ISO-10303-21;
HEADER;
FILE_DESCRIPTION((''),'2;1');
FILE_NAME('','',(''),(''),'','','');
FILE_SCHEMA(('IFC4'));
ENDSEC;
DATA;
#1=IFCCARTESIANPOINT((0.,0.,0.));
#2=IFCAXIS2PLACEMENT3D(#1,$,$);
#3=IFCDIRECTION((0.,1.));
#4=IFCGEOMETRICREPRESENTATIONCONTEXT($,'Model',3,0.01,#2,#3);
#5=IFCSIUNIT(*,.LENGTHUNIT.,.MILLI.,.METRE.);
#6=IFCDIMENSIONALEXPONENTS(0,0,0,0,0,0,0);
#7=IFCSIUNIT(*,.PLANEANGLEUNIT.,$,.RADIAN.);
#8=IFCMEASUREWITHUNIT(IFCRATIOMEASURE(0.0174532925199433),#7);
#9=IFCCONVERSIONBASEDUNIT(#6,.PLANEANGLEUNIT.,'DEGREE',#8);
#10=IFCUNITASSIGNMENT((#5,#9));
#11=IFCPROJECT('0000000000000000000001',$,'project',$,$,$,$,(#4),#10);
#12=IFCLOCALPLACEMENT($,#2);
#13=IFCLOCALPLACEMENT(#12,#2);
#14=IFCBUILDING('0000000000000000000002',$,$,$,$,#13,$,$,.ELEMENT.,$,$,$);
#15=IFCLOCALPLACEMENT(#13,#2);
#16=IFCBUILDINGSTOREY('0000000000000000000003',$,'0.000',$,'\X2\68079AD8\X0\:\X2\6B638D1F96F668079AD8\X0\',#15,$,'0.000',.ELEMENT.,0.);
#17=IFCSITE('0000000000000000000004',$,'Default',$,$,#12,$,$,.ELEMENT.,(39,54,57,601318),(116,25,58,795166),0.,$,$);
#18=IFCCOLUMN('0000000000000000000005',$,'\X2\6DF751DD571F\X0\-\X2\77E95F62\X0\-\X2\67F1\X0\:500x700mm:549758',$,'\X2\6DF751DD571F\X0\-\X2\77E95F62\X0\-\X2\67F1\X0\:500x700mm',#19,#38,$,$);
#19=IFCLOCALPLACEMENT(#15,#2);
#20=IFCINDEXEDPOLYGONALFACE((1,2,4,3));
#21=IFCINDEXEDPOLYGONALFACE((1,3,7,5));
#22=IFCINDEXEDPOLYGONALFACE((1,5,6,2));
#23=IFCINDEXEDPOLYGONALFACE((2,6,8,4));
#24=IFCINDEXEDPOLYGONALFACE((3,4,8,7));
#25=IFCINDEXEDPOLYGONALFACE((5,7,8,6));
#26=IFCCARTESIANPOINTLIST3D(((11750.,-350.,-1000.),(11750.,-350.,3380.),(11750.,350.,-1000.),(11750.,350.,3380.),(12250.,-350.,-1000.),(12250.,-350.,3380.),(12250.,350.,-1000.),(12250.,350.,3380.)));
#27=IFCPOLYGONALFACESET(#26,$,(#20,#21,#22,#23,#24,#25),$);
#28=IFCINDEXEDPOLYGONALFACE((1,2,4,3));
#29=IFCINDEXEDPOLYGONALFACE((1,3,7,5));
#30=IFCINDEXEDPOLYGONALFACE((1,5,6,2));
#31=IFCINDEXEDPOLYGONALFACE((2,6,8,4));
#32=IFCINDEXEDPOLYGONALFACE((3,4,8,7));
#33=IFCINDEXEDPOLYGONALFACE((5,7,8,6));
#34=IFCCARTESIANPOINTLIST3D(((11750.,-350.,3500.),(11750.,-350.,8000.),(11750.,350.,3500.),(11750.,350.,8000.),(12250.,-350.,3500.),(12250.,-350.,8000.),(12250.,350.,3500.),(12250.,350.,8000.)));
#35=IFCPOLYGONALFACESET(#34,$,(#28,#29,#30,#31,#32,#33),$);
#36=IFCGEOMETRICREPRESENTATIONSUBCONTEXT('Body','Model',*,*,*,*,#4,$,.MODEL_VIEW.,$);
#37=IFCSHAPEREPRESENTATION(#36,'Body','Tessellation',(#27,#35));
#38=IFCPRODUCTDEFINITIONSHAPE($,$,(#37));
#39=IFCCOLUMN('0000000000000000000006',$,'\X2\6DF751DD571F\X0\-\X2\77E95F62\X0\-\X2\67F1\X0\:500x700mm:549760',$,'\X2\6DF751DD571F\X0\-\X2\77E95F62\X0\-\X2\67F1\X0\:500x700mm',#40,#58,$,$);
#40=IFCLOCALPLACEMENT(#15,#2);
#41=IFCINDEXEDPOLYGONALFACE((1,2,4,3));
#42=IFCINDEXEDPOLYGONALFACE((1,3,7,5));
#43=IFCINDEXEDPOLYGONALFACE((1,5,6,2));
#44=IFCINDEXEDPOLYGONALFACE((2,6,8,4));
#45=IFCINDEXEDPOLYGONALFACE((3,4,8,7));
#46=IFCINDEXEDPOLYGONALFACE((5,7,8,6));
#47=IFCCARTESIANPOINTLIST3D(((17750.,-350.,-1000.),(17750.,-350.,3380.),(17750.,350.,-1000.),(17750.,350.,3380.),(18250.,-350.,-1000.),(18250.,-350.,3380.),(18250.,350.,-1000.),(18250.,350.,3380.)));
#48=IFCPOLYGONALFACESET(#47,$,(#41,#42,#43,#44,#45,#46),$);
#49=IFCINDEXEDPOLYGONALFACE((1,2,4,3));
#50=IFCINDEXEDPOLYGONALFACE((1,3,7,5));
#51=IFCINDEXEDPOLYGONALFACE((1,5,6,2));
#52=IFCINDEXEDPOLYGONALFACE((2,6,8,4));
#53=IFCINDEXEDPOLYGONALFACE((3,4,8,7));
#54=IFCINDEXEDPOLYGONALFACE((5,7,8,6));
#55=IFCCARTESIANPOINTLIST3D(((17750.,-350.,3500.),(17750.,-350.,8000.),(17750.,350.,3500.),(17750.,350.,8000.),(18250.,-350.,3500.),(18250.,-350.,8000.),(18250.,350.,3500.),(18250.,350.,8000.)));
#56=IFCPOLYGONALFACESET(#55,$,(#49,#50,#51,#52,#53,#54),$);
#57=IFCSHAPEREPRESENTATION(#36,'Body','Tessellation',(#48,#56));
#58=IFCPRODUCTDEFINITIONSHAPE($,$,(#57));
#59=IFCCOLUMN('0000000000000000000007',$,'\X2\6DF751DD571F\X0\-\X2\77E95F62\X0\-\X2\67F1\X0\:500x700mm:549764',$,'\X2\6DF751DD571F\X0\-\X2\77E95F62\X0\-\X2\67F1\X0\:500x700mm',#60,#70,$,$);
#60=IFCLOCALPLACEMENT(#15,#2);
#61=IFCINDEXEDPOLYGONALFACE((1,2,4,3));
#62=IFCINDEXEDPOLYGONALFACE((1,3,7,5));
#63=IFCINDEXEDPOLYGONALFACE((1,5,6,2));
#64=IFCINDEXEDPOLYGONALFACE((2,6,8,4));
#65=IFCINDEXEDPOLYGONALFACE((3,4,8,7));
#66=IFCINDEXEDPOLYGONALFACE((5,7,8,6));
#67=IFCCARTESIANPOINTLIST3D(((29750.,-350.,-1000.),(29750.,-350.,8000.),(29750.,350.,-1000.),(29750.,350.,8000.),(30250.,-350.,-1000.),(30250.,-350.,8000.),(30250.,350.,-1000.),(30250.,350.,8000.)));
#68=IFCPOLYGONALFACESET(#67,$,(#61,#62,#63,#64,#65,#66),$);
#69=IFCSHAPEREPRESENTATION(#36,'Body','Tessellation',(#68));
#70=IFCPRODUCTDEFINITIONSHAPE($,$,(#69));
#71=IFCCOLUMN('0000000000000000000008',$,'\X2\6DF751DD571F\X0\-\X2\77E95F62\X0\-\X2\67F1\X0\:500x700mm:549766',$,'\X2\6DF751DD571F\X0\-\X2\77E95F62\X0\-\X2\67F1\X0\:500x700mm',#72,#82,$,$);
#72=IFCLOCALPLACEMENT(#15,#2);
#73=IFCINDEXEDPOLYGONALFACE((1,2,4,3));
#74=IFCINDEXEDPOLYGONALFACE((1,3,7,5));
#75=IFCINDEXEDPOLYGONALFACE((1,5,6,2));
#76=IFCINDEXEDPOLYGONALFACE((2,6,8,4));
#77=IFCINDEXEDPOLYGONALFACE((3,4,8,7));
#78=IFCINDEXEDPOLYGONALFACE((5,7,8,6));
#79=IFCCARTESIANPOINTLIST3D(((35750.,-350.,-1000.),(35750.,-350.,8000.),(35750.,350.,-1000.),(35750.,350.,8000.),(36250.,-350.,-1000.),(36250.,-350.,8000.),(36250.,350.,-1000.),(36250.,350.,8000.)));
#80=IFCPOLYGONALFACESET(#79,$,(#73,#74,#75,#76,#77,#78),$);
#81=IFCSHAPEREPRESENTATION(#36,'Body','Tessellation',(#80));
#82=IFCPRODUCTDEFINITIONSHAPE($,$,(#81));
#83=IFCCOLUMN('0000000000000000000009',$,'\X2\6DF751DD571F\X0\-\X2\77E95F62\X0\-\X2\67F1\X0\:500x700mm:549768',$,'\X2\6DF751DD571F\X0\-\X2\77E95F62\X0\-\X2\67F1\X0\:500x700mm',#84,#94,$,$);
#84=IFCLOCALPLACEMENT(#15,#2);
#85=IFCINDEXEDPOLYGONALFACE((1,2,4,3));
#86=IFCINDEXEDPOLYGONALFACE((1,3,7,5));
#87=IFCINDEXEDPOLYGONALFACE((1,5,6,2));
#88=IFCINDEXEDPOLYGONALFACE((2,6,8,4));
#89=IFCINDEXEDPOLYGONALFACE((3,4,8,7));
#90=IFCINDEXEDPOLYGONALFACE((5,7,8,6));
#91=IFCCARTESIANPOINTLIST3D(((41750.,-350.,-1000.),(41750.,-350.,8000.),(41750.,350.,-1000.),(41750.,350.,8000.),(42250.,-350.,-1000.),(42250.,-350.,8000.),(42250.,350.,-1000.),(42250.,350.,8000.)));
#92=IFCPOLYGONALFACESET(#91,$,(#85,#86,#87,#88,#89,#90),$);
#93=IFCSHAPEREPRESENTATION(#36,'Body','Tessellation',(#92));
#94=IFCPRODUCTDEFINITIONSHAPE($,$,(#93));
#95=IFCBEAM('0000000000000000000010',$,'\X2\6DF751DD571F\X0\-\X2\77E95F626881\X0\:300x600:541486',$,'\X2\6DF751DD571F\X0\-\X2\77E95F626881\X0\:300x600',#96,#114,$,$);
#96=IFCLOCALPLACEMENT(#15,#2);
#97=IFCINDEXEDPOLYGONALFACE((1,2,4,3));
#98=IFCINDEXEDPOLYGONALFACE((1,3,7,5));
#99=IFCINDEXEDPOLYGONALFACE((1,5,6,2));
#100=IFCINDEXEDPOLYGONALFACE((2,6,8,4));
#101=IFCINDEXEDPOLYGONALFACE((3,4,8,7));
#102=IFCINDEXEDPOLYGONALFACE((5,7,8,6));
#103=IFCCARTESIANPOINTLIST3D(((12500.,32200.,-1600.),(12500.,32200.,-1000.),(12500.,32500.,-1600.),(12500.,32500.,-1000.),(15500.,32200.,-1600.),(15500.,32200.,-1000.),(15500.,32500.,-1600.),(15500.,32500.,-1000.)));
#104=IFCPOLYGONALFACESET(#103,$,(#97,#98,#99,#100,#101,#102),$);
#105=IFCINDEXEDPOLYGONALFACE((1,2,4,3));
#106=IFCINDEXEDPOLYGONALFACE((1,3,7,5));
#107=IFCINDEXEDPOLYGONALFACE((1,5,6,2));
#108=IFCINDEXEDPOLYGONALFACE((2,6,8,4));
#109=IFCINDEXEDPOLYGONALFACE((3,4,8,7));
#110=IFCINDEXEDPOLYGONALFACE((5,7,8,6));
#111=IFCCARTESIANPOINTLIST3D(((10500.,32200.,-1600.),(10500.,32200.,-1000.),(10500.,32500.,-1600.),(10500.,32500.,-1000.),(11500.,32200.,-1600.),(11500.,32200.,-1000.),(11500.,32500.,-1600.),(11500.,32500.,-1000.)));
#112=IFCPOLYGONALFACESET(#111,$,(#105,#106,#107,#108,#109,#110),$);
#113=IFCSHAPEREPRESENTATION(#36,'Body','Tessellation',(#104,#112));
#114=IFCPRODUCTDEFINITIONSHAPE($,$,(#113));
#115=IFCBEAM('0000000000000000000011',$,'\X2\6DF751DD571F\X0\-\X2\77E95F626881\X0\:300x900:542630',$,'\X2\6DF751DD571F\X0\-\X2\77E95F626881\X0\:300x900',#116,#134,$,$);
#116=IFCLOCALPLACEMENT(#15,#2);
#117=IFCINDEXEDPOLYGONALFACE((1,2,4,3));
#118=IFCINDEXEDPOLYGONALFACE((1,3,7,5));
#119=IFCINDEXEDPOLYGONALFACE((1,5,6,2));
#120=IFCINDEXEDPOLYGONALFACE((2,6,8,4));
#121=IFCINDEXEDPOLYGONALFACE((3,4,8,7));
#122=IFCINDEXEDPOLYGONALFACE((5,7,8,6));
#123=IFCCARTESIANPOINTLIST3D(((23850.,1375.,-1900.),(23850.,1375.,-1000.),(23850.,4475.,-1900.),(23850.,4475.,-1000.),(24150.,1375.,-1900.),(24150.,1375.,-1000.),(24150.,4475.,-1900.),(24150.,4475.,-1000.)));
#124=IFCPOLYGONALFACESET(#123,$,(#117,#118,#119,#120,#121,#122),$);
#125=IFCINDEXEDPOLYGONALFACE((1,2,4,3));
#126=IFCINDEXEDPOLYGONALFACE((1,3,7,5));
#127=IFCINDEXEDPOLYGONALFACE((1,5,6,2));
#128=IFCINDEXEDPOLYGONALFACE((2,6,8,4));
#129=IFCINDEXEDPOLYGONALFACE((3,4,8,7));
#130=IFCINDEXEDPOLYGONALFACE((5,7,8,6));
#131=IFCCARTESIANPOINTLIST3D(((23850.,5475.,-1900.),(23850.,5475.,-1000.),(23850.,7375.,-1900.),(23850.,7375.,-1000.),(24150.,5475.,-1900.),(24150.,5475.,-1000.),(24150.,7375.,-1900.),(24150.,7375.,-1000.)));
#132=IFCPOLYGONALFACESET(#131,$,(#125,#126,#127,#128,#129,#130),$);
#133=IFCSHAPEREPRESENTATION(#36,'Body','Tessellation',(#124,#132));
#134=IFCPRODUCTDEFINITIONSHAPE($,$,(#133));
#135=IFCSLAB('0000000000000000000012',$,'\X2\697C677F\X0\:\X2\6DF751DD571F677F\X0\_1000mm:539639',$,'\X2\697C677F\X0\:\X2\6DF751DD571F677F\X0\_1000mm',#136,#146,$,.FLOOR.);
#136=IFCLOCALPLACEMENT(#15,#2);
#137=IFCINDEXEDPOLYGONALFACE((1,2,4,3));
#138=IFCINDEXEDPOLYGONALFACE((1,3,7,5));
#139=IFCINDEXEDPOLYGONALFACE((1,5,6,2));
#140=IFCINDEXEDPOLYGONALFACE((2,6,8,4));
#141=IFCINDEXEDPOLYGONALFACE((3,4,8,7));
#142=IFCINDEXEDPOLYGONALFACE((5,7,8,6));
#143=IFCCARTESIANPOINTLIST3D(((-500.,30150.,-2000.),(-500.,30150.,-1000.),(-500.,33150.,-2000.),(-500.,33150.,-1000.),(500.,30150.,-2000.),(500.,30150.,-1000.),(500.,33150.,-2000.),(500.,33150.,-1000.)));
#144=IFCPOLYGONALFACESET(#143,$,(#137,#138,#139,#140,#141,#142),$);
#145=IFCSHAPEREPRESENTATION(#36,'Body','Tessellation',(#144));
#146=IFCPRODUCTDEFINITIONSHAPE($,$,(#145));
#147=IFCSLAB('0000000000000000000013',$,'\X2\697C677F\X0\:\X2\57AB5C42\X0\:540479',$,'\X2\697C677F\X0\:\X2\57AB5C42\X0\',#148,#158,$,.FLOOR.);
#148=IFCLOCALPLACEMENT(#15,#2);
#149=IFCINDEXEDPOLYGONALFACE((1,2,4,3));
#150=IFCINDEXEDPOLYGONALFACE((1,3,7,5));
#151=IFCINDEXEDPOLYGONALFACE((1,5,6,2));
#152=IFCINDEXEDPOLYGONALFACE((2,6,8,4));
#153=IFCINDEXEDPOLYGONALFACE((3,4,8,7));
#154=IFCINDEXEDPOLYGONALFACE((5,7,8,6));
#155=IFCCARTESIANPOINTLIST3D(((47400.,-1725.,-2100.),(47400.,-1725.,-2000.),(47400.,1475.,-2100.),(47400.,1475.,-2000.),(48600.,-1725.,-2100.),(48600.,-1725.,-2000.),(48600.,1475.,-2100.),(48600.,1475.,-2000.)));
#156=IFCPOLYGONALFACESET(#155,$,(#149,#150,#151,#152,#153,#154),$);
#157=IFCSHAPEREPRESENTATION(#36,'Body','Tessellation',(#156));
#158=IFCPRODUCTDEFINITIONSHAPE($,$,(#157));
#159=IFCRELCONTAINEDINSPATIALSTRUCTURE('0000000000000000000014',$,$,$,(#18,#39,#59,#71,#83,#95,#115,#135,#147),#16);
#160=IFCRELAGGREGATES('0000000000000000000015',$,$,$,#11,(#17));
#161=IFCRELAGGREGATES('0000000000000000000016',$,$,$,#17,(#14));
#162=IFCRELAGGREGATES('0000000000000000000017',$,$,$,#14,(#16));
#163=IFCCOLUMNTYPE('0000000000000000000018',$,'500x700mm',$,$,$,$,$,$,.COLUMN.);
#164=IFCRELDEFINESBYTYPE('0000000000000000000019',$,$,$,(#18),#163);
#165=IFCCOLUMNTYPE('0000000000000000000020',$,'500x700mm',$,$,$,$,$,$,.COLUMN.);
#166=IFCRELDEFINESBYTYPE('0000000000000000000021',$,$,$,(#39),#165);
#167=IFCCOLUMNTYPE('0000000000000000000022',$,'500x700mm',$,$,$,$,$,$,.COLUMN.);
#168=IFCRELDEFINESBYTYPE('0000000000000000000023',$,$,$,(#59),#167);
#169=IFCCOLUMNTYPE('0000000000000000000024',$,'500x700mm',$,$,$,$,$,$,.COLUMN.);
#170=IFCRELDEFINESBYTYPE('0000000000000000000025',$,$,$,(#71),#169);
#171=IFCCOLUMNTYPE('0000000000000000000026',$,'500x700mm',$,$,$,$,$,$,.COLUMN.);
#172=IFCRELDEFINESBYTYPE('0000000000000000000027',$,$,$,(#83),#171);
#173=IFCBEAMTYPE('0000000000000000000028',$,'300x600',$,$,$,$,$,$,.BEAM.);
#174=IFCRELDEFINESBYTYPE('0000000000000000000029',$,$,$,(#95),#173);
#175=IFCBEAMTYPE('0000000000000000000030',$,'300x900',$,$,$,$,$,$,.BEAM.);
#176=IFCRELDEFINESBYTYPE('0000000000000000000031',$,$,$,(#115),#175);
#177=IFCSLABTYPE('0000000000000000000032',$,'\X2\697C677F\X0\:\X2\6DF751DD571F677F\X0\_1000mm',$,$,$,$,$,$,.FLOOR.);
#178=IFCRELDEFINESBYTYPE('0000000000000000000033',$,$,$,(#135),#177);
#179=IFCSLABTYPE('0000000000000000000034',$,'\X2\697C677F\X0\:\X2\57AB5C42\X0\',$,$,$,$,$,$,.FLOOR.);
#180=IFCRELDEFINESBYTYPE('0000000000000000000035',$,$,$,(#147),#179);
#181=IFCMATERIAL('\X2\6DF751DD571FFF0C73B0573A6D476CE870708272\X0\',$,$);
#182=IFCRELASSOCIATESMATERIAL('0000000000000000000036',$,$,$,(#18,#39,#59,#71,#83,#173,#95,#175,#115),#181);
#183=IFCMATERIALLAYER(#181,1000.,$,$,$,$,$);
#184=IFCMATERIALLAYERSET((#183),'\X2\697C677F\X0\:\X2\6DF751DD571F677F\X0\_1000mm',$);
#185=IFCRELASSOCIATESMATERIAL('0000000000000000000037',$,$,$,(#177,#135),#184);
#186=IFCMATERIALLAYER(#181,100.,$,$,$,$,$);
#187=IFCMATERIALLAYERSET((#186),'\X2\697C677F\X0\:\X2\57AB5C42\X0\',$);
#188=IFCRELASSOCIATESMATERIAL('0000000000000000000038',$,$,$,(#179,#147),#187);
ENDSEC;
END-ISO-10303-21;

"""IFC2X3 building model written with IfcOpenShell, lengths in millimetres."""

from ifc_helpers import new_model, entity, si_unit, converted_unit, direction, frame, frame_2d, origin, origin_2d_with_axis, place, context, subcontext, project, spatial, rectangle, extrude, source, transform, mapped, material, layer, layer_set, layer_usage, type_object, type_shapes, element, save


model = new_model("IFC2X3")

# Units and contexts
model_context = context("Model", 3, precision=0.01, world=origin(), true_north=direction((0.0, 1.0)))
body_context = subcontext(model_context, "Body", "Model", "MODEL_VIEW")
ifc_project = project(units=[si_unit("LENGTHUNIT", "METRE", prefix="MILLI"), converted_unit("PLANEANGLEUNIT", "DEGREE", entity("IfcRatioMeasure", 0.0174532925199433), si_unit("PLANEANGLEUNIT", "RADIAN"), dimensions=[0, 0, 0, 0, 0, 0, 0])], contexts=[model_context])

# Site, building, storey
site_placement = place(None, origin())
site = spatial("IfcSite", under=ifc_project, at=site_placement, Name="Default", CompositionType="ELEMENT", RefLatitude=(39, 54, 57, 601318), RefLongitude=(116, 25, 58, 795166), RefElevation=0.0)
building_placement = place(site_placement, origin())
building = spatial("IfcBuilding", under=site, at=building_placement, CompositionType="ELEMENT")
storey_placement = place(building_placement, origin())
storey = spatial("IfcBuildingStorey", under=building, at=storey_placement, Name="0.000", ObjectType="标高:正负零标高", LongName="0.000", CompositionType="ELEMENT", Elevation=0.0)

# Columns
ifc_material_1 = material(Name="混凝土，现场浇注灰色")
column_type_1 = type_object("IfcColumnType", Name="500x700mm", PredefinedType="COLUMN")
shared_shape_1 = source(origin(), body_context, "Body", "SweptSolid", [
    extrude(rectangle(XDim=700.0, YDim=500.0, at=origin_2d_with_axis()), frame((12000.0, 0.0, -1000.0), z_axis=(0.0, 0.0, 1.0), x_axis=(0.0, -1.0, 0.0)), (0.0, 0.0, 1.0), 4380.0),
    extrude(rectangle(XDim=700.0, YDim=500.0, at=origin_2d_with_axis()), frame((12000.0, 0.0, 3500.0), z_axis=(0.0, 0.0, 1.0), x_axis=(0.0, -1.0, 0.0)), (0.0, 0.0, 1.0), 4500.0),
])
type_shapes(column_type_1, [shared_shape_1])
column_1_placement = place(storey_placement, origin())
element("IfcColumn", 1, at=column_1_placement, inside=storey, type_object=column_type_1, material=ifc_material_1, Name="混凝土-矩形-柱:500x700mm:549758", ObjectType="混凝土-矩形-柱:500x700mm", context=body_context, shape_type="MappedRepresentation", body=[
    mapped(shared_shape_1, transform((0.0, 0.0, 0.0), scale=1.0)),
])
column_type_2 = type_object("IfcColumnType", Name="500x700mm", PredefinedType="COLUMN")
shared_shape_2 = source(origin(), body_context, "Body", "SweptSolid", [
    extrude(rectangle(XDim=700.0, YDim=500.0, at=origin_2d_with_axis()), frame((18000.0, 0.0, -1000.0), z_axis=(0.0, 0.0, 1.0), x_axis=(0.0, -1.0, 0.0)), (0.0, 0.0, 1.0), 4380.0),
    extrude(rectangle(XDim=700.0, YDim=500.0, at=origin_2d_with_axis()), frame((18000.0, 0.0, 3500.0), z_axis=(0.0, 0.0, 1.0), x_axis=(0.0, -1.0, 0.0)), (0.0, 0.0, 1.0), 4500.0),
])
type_shapes(column_type_2, [shared_shape_2])
column_2_placement = place(storey_placement, origin())
element("IfcColumn", 2, at=column_2_placement, inside=storey, type_object=column_type_2, material=ifc_material_1, Name="混凝土-矩形-柱:500x700mm:549760", ObjectType="混凝土-矩形-柱:500x700mm", context=body_context, shape_type="MappedRepresentation", body=[
    mapped(shared_shape_2, transform((0.0, 0.0, 0.0), scale=1.0)),
])
column_type_3 = type_object("IfcColumnType", Name="500x700mm", PredefinedType="COLUMN")
shared_shape_3 = source(origin(), body_context, "Body", "SweptSolid", [
    extrude(rectangle(XDim=700.0, YDim=500.0, at=origin_2d_with_axis()), frame((30000.0, 0.0, -1000.0), z_axis=(0.0, 0.0, 1.0), x_axis=(0.0, -1.0, 0.0)), (0.0, 0.0, 1.0), 9000.0),
])
type_shapes(column_type_3, [shared_shape_3])
column_3_placement = place(storey_placement, origin())
element("IfcColumn", 3, at=column_3_placement, inside=storey, type_object=column_type_3, material=ifc_material_1, Name="混凝土-矩形-柱:500x700mm:549764", ObjectType="混凝土-矩形-柱:500x700mm", context=body_context, shape_type="MappedRepresentation", body=[
    mapped(shared_shape_3, transform((0.0, 0.0, 0.0), scale=1.0)),
])
column_type_4 = type_object("IfcColumnType", Name="500x700mm", PredefinedType="COLUMN")
shared_shape_4 = source(origin(), body_context, "Body", "SweptSolid", [
    extrude(rectangle(XDim=700.0, YDim=500.0, at=origin_2d_with_axis()), frame((36000.0, 0.0, -1000.0), z_axis=(0.0, 0.0, 1.0), x_axis=(0.0, -1.0, 0.0)), (0.0, 0.0, 1.0), 9000.0),
])
type_shapes(column_type_4, [shared_shape_4])
column_4_placement = place(storey_placement, origin())
element("IfcColumn", 4, at=column_4_placement, inside=storey, type_object=column_type_4, material=ifc_material_1, Name="混凝土-矩形-柱:500x700mm:549766", ObjectType="混凝土-矩形-柱:500x700mm", context=body_context, shape_type="MappedRepresentation", body=[
    mapped(shared_shape_4, transform((0.0, 0.0, 0.0), scale=1.0)),
])
column_type_5 = type_object("IfcColumnType", Name="500x700mm", PredefinedType="COLUMN")
shared_shape_5 = source(origin(), body_context, "Body", "SweptSolid", [
    extrude(rectangle(XDim=700.0, YDim=500.0, at=origin_2d_with_axis()), frame((42000.0, 0.0, -1000.0), z_axis=(0.0, 0.0, 1.0), x_axis=(0.0, -1.0, 0.0)), (0.0, 0.0, 1.0), 9000.0),
])
type_shapes(column_type_5, [shared_shape_5])
column_5_placement = place(storey_placement, origin())
element("IfcColumn", 5, at=column_5_placement, inside=storey, type_object=column_type_5, material=ifc_material_1, Name="混凝土-矩形-柱:500x700mm:549768", ObjectType="混凝土-矩形-柱:500x700mm", context=body_context, shape_type="MappedRepresentation", body=[
    mapped(shared_shape_5, transform((0.0, 0.0, 0.0), scale=1.0)),
])

# Beams
beam_type_1 = type_object("IfcBeamType", Name="300x600", PredefinedType="BEAM", material=ifc_material_1)
shared_shape_6 = source(origin(), body_context, "Body", "SweptSolid", [
    extrude(rectangle(XDim=600.0, YDim=300.0, at=frame_2d((0.0, 0.0), x_axis=(1.0, 0.0))), frame((12500.0, 32350.0, -1300.0), z_axis=(1.0, 0.0, 0.0), x_axis=(0.0, 0.0, -1.0)), (0.0, 0.0, 1.0), 3000.0),
    extrude(rectangle(XDim=600.0, YDim=300.0, at=frame_2d((0.0, 0.0), x_axis=(1.0, 0.0))), frame((10500.0, 32350.0, -1300.0), z_axis=(1.0, 0.0, 0.0), x_axis=(0.0, 0.0, -1.0)), (0.0, 0.0, 1.0), 1000.0),
])
type_shapes(beam_type_1, [shared_shape_6])
beam_1_placement = place(storey_placement, origin())
element("IfcBeam", 6, at=beam_1_placement, inside=storey, type_object=beam_type_1, material=ifc_material_1, Name="混凝土-矩形梁:300x600:541486", ObjectType="混凝土-矩形梁:300x600", context=body_context, shape_type="MappedRepresentation", body=[
    mapped(shared_shape_6, transform((0.0, 0.0, 0.0), scale=1.0)),
])
beam_type_2 = type_object("IfcBeamType", Name="300x900", PredefinedType="BEAM", material=ifc_material_1)
shared_shape_7 = source(origin(), body_context, "Body", "SweptSolid", [
    extrude(rectangle(XDim=900.0, YDim=300.0, at=frame_2d((0.0, 0.0), x_axis=(0.0, 1.0))), frame((24000.0, 4475.0, -1450.0), z_axis=(0.0, -1.0, 0.0), x_axis=(-1.0, 0.0, 0.0)), (0.0, 0.0, 1.0), 3100.0),
    extrude(rectangle(XDim=900.0, YDim=300.0, at=frame_2d((0.0, 0.0), x_axis=(0.0, 1.0))), frame((24000.0, 7375.0, -1450.0), z_axis=(0.0, -1.0, 0.0), x_axis=(-1.0, 0.0, 0.0)), (0.0, 0.0, 1.0), 1900.0),
])
type_shapes(beam_type_2, [shared_shape_7])
beam_2_placement = place(storey_placement, origin())
element("IfcBeam", 7, at=beam_2_placement, inside=storey, type_object=beam_type_2, material=ifc_material_1, Name="混凝土-矩形梁:300x900:542630", ObjectType="混凝土-矩形梁:300x900", context=body_context, shape_type="MappedRepresentation", body=[
    mapped(shared_shape_7, transform((0.0, 0.0, 0.0), scale=1.0)),
])

# Slabs
ifc_layer_1 = layer(ifc_material_1, 1000.0)
ifc_layer_set_1 = layer_set([ifc_layer_1], Name="楼板:混凝土板_1000mm")
ifc_layer_usage_1 = layer_usage(ifc_layer_set_1, "AXIS3", "POSITIVE", 0.0)
slab_type_1 = type_object("IfcSlabType", Name="楼板:混凝土板_1000mm", PredefinedType="FLOOR", material=ifc_layer_set_1)
slab_1_placement = place(storey_placement, origin())
element("IfcSlab", 8, at=slab_1_placement, inside=storey, type_object=slab_type_1, material=ifc_layer_usage_1, Name="楼板:混凝土板_1000mm:539639", ObjectType="楼板:混凝土板_1000mm", PredefinedType="FLOOR", context=body_context, shape_type="SweptSolid", body=[
    extrude(rectangle(XDim=3000.0, YDim=1000.0, at=frame_2d((0.0, 0.0), x_axis=(1.0, 0.0))), frame((0.0, 31650.0, -1000.0), z_axis=(0.0, 0.0, -1.0), x_axis=(0.0, 1.0, 0.0)), (0.0, 0.0, 1.0), 1000.0),
])
ifc_layer_2 = layer(ifc_material_1, 100.0)
ifc_layer_set_2 = layer_set([ifc_layer_2], Name="楼板:垫层")
ifc_layer_usage_2 = layer_usage(ifc_layer_set_2, "AXIS3", "POSITIVE", 0.0)
slab_type_2 = type_object("IfcSlabType", Name="楼板:垫层", PredefinedType="FLOOR", material=ifc_layer_set_2)
slab_2_placement = place(storey_placement, origin())
element("IfcSlab", 9, at=slab_2_placement, inside=storey, type_object=slab_type_2, material=ifc_layer_usage_2, Name="楼板:垫层:540479", ObjectType="楼板:垫层", PredefinedType="FLOOR", context=body_context, shape_type="SweptSolid", body=[
    extrude(rectangle(XDim=3200.0, YDim=1200.0, at=origin_2d_with_axis()), frame((48000.0, -125.0, -2000.0), z_axis=(0.0, 0.0, -1.0), x_axis=(0.0, 1.0, 0.0)), (0.0, 0.0, 1.0), 100.0),
])

save(model, "model.ifc")
